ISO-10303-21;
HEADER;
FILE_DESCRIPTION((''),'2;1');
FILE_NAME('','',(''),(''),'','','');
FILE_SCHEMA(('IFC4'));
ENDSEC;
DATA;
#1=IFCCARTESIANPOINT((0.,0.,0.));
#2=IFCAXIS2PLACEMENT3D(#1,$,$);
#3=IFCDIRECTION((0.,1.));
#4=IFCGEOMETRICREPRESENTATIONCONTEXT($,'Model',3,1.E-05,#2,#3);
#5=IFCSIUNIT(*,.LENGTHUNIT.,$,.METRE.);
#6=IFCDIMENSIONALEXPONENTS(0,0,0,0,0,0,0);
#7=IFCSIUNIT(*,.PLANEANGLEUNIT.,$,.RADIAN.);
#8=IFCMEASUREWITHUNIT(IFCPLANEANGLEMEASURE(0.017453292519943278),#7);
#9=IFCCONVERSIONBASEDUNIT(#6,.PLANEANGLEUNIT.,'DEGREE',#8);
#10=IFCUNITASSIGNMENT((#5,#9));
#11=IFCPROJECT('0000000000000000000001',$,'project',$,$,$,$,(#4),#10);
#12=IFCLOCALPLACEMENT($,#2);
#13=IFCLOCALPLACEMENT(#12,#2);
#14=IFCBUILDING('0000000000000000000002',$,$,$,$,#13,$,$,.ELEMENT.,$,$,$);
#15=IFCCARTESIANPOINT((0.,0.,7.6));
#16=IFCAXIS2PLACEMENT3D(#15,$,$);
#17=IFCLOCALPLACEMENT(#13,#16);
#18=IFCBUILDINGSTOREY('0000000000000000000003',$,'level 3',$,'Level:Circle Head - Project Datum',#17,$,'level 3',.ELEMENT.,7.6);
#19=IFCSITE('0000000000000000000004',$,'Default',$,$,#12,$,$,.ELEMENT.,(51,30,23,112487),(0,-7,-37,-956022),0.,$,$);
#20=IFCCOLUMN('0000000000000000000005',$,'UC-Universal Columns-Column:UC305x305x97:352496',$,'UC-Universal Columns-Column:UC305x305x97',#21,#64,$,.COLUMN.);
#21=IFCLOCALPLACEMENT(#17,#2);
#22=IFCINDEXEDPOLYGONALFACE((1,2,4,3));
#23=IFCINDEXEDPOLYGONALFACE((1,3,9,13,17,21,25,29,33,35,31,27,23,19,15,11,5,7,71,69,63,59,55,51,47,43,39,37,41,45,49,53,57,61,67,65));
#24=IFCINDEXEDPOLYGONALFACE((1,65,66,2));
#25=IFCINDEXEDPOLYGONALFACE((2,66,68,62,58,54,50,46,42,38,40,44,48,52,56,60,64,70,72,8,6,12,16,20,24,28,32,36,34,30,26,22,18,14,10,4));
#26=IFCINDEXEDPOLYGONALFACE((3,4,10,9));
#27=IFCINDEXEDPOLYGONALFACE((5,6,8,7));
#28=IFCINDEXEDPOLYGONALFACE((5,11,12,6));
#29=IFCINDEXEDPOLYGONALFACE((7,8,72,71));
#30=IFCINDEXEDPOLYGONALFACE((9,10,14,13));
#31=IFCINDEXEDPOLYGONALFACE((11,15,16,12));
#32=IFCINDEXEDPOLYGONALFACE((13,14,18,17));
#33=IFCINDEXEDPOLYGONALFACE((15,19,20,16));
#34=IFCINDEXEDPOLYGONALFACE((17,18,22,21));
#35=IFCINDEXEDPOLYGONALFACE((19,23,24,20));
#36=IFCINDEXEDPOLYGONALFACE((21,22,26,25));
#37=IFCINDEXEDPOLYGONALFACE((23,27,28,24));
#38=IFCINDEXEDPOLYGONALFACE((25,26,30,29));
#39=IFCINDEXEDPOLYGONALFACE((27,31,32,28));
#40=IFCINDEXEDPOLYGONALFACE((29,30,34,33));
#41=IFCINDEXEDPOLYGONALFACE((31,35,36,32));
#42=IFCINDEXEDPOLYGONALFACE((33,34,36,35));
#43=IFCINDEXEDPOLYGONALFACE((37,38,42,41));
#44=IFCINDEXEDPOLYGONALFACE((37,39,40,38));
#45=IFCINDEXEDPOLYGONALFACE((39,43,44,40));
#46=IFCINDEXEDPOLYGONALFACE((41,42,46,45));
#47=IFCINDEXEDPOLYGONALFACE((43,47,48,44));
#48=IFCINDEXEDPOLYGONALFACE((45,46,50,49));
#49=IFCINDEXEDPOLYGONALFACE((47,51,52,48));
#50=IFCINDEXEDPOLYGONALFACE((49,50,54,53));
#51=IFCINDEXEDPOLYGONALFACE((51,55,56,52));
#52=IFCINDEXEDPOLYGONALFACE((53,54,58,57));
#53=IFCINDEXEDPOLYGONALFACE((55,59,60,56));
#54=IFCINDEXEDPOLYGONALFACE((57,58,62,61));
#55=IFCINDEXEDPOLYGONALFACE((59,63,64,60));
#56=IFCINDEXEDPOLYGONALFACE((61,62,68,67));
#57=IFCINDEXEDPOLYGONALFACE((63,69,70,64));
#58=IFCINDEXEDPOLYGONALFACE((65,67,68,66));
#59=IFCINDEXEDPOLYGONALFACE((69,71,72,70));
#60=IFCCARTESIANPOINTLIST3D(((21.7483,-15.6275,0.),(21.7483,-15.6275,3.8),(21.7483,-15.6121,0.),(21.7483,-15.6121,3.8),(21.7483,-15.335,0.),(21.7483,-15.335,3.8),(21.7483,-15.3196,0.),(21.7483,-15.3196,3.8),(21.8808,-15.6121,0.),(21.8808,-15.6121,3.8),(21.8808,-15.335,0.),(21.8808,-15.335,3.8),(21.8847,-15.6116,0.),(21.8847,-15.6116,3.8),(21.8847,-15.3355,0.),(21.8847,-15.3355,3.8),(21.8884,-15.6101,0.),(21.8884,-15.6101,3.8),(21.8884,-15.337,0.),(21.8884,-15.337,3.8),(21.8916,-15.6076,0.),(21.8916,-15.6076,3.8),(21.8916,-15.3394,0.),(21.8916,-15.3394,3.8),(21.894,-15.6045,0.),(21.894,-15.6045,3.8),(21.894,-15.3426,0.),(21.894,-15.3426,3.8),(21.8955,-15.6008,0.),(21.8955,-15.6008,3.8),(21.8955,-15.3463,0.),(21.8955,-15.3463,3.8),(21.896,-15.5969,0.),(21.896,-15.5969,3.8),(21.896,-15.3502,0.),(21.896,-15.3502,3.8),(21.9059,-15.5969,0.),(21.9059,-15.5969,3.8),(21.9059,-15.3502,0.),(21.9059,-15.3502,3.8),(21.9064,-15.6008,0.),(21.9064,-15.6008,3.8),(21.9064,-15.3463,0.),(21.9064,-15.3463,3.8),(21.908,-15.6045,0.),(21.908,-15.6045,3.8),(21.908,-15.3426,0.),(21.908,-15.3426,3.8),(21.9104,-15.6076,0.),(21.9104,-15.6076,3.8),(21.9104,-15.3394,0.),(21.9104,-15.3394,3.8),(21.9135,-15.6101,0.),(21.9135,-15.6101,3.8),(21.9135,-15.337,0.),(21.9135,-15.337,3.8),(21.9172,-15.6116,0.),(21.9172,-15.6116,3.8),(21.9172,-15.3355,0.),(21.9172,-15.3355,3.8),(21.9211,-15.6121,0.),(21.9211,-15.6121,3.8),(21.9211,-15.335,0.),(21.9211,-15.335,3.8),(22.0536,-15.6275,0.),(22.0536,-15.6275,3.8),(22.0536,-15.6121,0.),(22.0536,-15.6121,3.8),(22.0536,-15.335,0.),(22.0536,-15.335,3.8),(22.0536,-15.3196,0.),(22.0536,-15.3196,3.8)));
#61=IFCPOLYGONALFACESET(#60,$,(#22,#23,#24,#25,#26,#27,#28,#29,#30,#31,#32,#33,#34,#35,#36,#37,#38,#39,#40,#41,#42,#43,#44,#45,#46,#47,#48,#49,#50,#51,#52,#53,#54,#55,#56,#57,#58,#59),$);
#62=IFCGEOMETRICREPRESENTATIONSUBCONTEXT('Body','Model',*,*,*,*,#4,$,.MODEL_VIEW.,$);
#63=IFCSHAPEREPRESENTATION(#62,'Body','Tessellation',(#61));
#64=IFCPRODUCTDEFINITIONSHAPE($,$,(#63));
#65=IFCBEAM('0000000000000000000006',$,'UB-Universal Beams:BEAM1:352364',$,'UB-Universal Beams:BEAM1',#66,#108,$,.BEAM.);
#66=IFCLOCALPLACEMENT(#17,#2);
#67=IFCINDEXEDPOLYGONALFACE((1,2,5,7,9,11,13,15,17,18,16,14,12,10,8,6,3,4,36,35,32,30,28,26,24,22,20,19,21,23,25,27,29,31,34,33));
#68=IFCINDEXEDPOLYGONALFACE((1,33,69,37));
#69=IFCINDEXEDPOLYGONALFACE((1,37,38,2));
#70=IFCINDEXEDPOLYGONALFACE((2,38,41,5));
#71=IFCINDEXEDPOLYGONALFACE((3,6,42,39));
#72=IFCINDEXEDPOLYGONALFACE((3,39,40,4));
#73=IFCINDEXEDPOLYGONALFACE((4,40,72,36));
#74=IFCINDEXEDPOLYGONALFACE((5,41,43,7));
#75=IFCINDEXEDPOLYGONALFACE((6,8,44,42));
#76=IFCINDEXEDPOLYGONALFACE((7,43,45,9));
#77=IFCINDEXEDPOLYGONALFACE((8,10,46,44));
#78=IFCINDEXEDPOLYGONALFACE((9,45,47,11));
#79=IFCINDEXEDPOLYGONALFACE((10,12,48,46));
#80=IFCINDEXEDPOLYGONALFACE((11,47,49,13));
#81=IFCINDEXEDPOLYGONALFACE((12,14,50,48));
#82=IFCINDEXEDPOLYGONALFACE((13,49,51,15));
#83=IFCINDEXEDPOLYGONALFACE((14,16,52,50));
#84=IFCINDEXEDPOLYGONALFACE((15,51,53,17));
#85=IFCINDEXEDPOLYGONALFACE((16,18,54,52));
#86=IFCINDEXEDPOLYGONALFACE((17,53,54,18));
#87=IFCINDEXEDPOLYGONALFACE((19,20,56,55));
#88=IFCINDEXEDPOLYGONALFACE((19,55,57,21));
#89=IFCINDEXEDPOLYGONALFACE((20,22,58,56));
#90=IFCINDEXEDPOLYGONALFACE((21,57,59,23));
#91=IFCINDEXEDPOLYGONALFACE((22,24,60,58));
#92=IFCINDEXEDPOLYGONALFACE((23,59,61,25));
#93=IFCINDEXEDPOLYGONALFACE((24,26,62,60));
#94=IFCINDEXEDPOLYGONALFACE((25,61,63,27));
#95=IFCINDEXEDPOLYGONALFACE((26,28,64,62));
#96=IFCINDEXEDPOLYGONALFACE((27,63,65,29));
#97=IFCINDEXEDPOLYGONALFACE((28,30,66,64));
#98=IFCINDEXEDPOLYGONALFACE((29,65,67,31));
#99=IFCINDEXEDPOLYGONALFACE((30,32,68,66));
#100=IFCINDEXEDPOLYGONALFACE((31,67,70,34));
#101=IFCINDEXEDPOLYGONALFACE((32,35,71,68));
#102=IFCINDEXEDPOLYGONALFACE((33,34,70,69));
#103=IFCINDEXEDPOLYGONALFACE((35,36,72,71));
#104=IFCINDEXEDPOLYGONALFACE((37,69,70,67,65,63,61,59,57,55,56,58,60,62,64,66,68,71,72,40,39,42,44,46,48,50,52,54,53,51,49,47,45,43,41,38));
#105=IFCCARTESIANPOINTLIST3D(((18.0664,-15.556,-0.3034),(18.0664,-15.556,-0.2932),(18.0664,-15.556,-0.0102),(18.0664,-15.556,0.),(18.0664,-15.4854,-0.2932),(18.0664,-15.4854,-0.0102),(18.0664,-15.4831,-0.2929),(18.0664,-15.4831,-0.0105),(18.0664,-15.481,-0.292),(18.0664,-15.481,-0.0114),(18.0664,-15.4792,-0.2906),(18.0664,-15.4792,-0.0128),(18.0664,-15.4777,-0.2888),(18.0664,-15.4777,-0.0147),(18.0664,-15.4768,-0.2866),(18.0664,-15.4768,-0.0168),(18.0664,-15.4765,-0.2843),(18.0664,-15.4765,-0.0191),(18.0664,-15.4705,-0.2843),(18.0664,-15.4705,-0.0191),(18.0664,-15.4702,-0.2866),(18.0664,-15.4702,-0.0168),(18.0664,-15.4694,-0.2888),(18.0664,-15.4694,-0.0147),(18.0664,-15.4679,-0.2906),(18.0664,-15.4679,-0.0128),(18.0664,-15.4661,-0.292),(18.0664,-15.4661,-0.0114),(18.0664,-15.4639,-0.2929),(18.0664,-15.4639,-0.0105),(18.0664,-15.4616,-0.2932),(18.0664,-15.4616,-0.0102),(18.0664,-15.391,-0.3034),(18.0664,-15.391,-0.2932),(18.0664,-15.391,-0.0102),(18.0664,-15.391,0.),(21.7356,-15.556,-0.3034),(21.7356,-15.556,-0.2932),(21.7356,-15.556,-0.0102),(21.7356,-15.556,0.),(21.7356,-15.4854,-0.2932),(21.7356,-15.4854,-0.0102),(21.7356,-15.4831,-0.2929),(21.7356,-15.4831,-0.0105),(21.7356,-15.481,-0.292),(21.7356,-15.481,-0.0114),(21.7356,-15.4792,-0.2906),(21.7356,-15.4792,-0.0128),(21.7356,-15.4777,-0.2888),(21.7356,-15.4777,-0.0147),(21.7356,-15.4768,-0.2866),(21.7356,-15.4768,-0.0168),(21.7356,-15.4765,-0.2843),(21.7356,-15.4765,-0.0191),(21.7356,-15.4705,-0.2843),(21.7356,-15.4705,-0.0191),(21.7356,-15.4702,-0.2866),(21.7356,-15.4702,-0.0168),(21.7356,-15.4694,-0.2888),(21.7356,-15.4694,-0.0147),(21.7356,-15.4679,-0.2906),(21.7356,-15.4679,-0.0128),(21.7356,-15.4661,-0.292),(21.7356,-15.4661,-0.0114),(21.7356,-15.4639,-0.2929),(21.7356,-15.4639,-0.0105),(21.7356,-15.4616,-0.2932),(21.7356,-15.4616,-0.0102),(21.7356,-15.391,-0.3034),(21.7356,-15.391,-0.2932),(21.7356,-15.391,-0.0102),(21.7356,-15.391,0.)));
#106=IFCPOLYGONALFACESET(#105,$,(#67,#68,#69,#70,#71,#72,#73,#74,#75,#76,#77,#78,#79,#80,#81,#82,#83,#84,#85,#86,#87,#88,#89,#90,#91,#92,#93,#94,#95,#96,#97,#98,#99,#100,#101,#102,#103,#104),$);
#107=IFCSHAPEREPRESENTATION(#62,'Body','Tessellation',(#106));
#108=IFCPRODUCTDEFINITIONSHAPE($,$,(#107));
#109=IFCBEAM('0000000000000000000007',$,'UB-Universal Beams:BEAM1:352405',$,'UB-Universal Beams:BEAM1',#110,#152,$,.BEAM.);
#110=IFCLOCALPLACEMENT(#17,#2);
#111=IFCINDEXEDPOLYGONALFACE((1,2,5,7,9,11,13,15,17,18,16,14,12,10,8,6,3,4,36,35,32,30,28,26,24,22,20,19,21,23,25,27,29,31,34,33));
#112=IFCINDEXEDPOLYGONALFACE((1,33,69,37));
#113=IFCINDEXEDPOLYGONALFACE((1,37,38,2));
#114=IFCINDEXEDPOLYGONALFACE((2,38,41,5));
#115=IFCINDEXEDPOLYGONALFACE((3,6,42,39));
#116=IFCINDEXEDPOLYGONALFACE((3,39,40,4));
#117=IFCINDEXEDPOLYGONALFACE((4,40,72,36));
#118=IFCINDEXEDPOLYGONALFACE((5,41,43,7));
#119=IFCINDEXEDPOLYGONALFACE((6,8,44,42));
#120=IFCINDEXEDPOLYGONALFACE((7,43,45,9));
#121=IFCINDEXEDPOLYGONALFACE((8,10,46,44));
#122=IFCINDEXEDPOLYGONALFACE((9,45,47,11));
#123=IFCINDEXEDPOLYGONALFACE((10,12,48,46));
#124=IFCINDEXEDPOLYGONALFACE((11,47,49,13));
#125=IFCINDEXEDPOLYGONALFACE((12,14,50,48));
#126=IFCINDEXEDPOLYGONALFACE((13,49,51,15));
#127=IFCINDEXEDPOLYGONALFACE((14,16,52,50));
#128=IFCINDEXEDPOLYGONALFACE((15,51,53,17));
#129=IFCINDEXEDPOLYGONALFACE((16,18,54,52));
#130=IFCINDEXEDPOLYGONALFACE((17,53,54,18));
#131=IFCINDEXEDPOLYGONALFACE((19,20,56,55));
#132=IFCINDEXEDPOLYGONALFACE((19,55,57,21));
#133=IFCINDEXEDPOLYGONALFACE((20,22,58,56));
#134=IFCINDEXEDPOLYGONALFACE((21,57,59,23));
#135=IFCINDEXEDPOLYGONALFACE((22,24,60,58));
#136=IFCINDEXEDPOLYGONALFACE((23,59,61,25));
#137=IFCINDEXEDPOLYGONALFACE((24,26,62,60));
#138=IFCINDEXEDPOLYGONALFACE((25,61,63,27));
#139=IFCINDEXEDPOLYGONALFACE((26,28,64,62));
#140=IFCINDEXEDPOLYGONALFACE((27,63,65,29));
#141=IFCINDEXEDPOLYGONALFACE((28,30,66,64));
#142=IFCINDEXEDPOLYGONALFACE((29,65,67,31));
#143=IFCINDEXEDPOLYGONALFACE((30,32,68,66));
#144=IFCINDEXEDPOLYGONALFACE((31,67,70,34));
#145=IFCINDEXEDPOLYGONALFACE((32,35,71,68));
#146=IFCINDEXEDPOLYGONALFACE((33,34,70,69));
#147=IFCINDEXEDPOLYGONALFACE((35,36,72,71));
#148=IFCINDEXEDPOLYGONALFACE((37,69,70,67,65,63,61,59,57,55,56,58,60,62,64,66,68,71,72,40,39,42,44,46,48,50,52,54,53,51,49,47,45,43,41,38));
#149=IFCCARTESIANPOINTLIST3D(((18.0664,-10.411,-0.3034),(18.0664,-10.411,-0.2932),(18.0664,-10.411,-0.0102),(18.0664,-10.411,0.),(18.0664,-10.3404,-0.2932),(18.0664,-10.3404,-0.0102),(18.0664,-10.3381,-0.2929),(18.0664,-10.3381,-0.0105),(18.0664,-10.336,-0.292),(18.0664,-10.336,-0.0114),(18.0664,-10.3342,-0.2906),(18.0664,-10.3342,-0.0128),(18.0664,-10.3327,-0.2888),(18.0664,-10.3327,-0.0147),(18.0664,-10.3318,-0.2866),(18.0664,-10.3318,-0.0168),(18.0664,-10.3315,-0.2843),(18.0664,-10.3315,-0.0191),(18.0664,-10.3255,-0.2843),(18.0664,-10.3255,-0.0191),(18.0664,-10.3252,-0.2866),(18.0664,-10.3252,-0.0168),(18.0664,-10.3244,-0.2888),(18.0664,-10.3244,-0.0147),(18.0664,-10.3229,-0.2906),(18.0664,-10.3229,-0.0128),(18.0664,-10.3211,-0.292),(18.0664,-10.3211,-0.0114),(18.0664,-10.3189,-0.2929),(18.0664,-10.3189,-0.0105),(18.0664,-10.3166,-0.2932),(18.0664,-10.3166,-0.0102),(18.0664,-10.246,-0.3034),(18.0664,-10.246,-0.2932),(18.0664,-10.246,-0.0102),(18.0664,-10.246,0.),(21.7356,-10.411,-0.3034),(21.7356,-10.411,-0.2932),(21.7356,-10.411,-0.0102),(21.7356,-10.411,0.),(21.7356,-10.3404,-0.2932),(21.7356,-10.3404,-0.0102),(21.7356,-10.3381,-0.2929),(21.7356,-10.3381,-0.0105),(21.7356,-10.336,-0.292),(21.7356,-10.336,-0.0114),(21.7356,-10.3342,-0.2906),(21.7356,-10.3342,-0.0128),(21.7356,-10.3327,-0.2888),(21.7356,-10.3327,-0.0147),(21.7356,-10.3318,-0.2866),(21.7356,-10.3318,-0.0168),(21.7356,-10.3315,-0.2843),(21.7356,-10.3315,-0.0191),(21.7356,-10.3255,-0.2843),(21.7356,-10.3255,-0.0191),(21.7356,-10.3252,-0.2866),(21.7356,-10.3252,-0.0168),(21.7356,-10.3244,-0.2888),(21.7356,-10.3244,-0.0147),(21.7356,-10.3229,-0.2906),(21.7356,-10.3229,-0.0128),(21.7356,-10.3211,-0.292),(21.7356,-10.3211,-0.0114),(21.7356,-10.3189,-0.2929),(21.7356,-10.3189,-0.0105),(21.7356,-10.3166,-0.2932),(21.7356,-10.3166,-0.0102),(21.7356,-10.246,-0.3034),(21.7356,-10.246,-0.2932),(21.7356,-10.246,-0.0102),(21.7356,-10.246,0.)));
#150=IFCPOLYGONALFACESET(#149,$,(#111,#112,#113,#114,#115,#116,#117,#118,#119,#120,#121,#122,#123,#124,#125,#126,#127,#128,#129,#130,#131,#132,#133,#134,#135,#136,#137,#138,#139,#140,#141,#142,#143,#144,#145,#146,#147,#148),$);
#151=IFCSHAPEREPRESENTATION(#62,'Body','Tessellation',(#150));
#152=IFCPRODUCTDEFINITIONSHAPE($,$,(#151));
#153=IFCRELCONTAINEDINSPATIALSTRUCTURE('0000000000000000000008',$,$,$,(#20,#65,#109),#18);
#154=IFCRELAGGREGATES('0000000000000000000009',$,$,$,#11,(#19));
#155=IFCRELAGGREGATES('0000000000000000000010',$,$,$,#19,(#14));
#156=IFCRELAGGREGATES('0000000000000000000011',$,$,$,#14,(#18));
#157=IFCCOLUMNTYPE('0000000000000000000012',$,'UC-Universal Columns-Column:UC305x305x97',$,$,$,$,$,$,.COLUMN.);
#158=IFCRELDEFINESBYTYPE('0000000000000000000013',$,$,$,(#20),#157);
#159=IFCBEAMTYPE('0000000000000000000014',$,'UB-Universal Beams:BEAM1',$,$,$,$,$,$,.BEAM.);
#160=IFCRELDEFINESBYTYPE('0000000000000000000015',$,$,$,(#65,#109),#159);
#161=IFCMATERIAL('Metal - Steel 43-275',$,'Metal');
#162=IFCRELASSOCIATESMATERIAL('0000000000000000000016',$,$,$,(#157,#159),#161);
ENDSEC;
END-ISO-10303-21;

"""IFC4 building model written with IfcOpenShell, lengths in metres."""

from ifc_helpers import new_model, entity, si_unit, converted_unit, direction, frame, frame_2d, origin, origin_2d_with_axis, place, context, subcontext, project, spatial, polyline, circle_curve, parameter, trimmed, segment, composite_curve, i_section, outline, extrude, source, transform, mapped, material, material_profile, profile_set, type_object, type_shapes, element, save


model = new_model("IFC4")

# Units and contexts
model_context = context("Model", 3, precision=1e-05, world=origin(), true_north=direction((0.0, 1.0)))
body_context = subcontext(model_context, "Body", "Model", "MODEL_VIEW")
ifc_project = project(units=[si_unit("LENGTHUNIT", "METRE"), converted_unit("PLANEANGLEUNIT", "DEGREE", entity("IfcPlaneAngleMeasure", 0.017453292519943278), si_unit("PLANEANGLEUNIT", "RADIAN"), dimensions=[0, 0, 0, 0, 0, 0, 0])], contexts=[model_context])

# Site, building, storey
site_placement = place(None, origin())
site = spatial("IfcSite", under=ifc_project, at=site_placement, Name="Default", CompositionType="ELEMENT", RefLatitude=(51, 30, 23, 112487), RefLongitude=(0, -7, -37, -956022), RefElevation=0.0)
building_placement = place(site_placement, origin())
building = spatial("IfcBuilding", under=site, at=building_placement, CompositionType="ELEMENT")
storey_placement = place(building_placement, frame((0.0, 0.0, 7.6)))
storey = spatial("IfcBuildingStorey", under=building, at=storey_placement, Name="level 3", ObjectType="Level:Circle Head - Project Datum", LongName="level 3", CompositionType="ELEMENT", Elevation=7.6)

# Column
ifc_material_1 = material(Name="Metal - Steel 43-275", Category="Metal")
ifc_material_profile_1 = material_profile(ifc_material_1, i_section(OverallWidth=0.3053, OverallDepth=0.3079, WebThickness=0.0099, FlangeThickness=0.0154, FilletRadius=0.0152, at=frame_2d((0.0, 0.0), x_axis=(1.0, 0.0))), Name="UC305x305x97")
ifc_profile_set_1 = profile_set([ifc_material_profile_1], Name="UC305x305x97")
column_type = type_object("IfcColumnType", Name="UC-Universal Columns-Column:UC305x305x97", PredefinedType="COLUMN", material=ifc_profile_set_1)
shared_shape_1 = source(origin(), body_context, "Body", "SweptSolid", [
    extrude(i_section(OverallWidth=0.3053, OverallDepth=0.3079, WebThickness=0.0099, FlangeThickness=0.0154, FilletRadius=0.0152, at=origin_2d_with_axis()), frame((0.0, 0.0, 7.6), z_axis=(0.0, 0.0, 1.0), x_axis=(-1.0, 0.0, 0.0)), (0.0, 0.0, 1.0), 3.8),
])
type_shapes(column_type, [shared_shape_1])
column_placement = place(storey_placement, frame((21.901, -15.4735, -7.6)))
element("IfcColumn", 1, at=column_placement, inside=storey, type_object=column_type, Name="UC-Universal Columns-Column:UC305x305x97:352496", ObjectType="UC-Universal Columns-Column:UC305x305x97", PredefinedType="COLUMN", context=body_context, shape_type="MappedRepresentation", body=[
    mapped(shared_shape_1, transform((0.0, 0.0, 0.0), scale=1.0)),
])

# Beams
ifc_material_profile_2 = material_profile(ifc_material_1, outline(composite_curve([segment(polyline([(-0.0825, -0.1415), (-0.0825, -0.1517)]), True, "CONTINUOUS"), segment(polyline([(-0.0825, -0.1517), (0.0825, -0.1517)]), True, "CONTINUOUS"), segment(polyline([(0.0825, -0.1517), (0.0825, -0.1415)]), True, "CONTINUOUS"), segment(polyline([(0.0825, -0.1415), (0.0119, -0.1415)]), True, "CONTINUOUS"), segment(trimmed(circle_curve(frame_2d((0.0119, -0.1326), x_axis=(1.0, 0.0)), 0.0089), [parameter(180.0)], [parameter(270.0)], True, "PARAMETER"), False, "CONTINUOUS"), segment(polyline([(0.003, -0.1326), (0.003, 0.1326)]), True, "CONTINUOUS"), segment(trimmed(circle_curve(frame_2d((0.0119, 0.1326), x_axis=(1.0, 0.0)), 0.0089), [parameter(90.0)], [parameter(180.0)], True, "PARAMETER"), False, "CONTINUOUS"), segment(polyline([(0.0119, 0.1415), (0.0825, 0.1415)]), True, "CONTINUOUS"), segment(polyline([(0.0825, 0.1415), (0.0825, 0.1517)]), True, "CONTINUOUS"), segment(polyline([(0.0825, 0.1517), (-0.0825, 0.1517)]), True, "CONTINUOUS"), segment(polyline([(-0.0825, 0.1517), (-0.0825, 0.1415)]), True, "CONTINUOUS"), segment(polyline([(-0.0825, 0.1415), (-0.0119, 0.1415)]), True, "CONTINUOUS"), segment(trimmed(circle_curve(frame_2d((-0.0119, 0.1326), x_axis=(1.0, 0.0)), 0.0089), [parameter(360.0)], [parameter(90.0)], True, "PARAMETER"), False, "CONTINUOUS"), segment(polyline([(-0.003, 0.1326), (-0.003, -0.1326)]), True, "CONTINUOUS"), segment(trimmed(circle_curve(frame_2d((-0.0119, -0.1326), x_axis=(1.0, 0.0)), 0.0089), [parameter(270.0)], [parameter(360.0)], True, "PARAMETER"), False, "CONTINUOUS"), segment(polyline([(-0.0119, -0.1415), (-0.0825, -0.1415)]), True, "CONTINUOUS")], self_intersect=False)), Name="BEAM1")
ifc_profile_set_2 = profile_set([ifc_material_profile_2], Name="BEAM1")
beam_type_1 = type_object("IfcBeamType", Name="UB-Universal Beams:BEAM1", PredefinedType="BEAM", material=ifc_profile_set_2)
shared_shape_2 = source(origin(), body_context, "Body", "SweptSolid", [
    extrude(outline(composite_curve([segment(polyline([(-0.0825, -0.1415), (-0.0825, -0.1517)]), True, "CONTINUOUS"), segment(polyline([(-0.0825, -0.1517), (0.0825, -0.1517)]), True, "CONTINUOUS"), segment(polyline([(0.0825, -0.1517), (0.0825, -0.1415)]), True, "CONTINUOUS"), segment(polyline([(0.0825, -0.1415), (0.0119, -0.1415)]), True, "CONTINUOUS"), segment(trimmed(circle_curve(frame_2d((0.0119, -0.1326), x_axis=(0.0, -1.0)), 0.0089), [parameter(270.0)], [parameter(360.0)], True, "PARAMETER"), False, "CONTINUOUS"), segment(polyline([(0.003, -0.1326), (0.003, 0.1326)]), True, "CONTINUOUS"), segment(trimmed(circle_curve(frame_2d((0.0119, 0.1326), x_axis=(-1.0, 0.0)), 0.0089), [parameter(270.0)], [parameter(360.0)], True, "PARAMETER"), False, "CONTINUOUS"), segment(polyline([(0.0119, 0.1415), (0.0825, 0.1415)]), True, "CONTINUOUS"), segment(polyline([(0.0825, 0.1415), (0.0825, 0.1517)]), True, "CONTINUOUS"), segment(polyline([(0.0825, 0.1517), (-0.0825, 0.1517)]), True, "CONTINUOUS"), segment(polyline([(-0.0825, 0.1517), (-0.0825, 0.1415)]), True, "CONTINUOUS"), segment(polyline([(-0.0825, 0.1415), (-0.0119, 0.1415)]), True, "CONTINUOUS"), segment(trimmed(circle_curve(frame_2d((-0.0119, 0.1326), x_axis=(0.0, 1.0)), 0.0089), [parameter(270.0)], [parameter(360.0)], True, "PARAMETER"), False, "CONTINUOUS"), segment(polyline([(-0.003, 0.1326), (-0.003, -0.1326)]), True, "CONTINUOUS"), segment(trimmed(circle_curve(frame_2d((-0.0119, -0.1326), x_axis=(1.0, 0.0)), 0.0089), [parameter(270.0)], [parameter(0.0)], True, "PARAMETER"), False, "CONTINUOUS"), segment(polyline([(-0.0119, -0.1415), (-0.0825, -0.1415)]), True, "CONTINUOUS")], self_intersect=False)), frame((-1.8346, 0.0, 0.0), z_axis=(-1.0, 0.0, 0.0), x_axis=(0.0, -1.0, 0.0)), (0.0, 0.0, -1.0), 3.6692),
])
type_shapes(beam_type_1, [shared_shape_2])
for number, where, name in (
    (2, (19.901, -15.4735, -0.1517), "UB-Universal Beams:BEAM1:352364"),
    (3, (19.901, -10.3285, -0.1517), "UB-Universal Beams:BEAM1:352405"),
):
    element("IfcBeam", number, at=place(storey_placement, frame(where)), inside=storey, type_object=beam_type_1, Name=name, ObjectType="UB-Universal Beams:BEAM1", PredefinedType="BEAM", context=body_context, shape_type="MappedRepresentation", body=[
        mapped(shared_shape_2, transform((0.0, 0.0, 0.0), scale=1.0)),
    ])

save(model, "model.ifc")
